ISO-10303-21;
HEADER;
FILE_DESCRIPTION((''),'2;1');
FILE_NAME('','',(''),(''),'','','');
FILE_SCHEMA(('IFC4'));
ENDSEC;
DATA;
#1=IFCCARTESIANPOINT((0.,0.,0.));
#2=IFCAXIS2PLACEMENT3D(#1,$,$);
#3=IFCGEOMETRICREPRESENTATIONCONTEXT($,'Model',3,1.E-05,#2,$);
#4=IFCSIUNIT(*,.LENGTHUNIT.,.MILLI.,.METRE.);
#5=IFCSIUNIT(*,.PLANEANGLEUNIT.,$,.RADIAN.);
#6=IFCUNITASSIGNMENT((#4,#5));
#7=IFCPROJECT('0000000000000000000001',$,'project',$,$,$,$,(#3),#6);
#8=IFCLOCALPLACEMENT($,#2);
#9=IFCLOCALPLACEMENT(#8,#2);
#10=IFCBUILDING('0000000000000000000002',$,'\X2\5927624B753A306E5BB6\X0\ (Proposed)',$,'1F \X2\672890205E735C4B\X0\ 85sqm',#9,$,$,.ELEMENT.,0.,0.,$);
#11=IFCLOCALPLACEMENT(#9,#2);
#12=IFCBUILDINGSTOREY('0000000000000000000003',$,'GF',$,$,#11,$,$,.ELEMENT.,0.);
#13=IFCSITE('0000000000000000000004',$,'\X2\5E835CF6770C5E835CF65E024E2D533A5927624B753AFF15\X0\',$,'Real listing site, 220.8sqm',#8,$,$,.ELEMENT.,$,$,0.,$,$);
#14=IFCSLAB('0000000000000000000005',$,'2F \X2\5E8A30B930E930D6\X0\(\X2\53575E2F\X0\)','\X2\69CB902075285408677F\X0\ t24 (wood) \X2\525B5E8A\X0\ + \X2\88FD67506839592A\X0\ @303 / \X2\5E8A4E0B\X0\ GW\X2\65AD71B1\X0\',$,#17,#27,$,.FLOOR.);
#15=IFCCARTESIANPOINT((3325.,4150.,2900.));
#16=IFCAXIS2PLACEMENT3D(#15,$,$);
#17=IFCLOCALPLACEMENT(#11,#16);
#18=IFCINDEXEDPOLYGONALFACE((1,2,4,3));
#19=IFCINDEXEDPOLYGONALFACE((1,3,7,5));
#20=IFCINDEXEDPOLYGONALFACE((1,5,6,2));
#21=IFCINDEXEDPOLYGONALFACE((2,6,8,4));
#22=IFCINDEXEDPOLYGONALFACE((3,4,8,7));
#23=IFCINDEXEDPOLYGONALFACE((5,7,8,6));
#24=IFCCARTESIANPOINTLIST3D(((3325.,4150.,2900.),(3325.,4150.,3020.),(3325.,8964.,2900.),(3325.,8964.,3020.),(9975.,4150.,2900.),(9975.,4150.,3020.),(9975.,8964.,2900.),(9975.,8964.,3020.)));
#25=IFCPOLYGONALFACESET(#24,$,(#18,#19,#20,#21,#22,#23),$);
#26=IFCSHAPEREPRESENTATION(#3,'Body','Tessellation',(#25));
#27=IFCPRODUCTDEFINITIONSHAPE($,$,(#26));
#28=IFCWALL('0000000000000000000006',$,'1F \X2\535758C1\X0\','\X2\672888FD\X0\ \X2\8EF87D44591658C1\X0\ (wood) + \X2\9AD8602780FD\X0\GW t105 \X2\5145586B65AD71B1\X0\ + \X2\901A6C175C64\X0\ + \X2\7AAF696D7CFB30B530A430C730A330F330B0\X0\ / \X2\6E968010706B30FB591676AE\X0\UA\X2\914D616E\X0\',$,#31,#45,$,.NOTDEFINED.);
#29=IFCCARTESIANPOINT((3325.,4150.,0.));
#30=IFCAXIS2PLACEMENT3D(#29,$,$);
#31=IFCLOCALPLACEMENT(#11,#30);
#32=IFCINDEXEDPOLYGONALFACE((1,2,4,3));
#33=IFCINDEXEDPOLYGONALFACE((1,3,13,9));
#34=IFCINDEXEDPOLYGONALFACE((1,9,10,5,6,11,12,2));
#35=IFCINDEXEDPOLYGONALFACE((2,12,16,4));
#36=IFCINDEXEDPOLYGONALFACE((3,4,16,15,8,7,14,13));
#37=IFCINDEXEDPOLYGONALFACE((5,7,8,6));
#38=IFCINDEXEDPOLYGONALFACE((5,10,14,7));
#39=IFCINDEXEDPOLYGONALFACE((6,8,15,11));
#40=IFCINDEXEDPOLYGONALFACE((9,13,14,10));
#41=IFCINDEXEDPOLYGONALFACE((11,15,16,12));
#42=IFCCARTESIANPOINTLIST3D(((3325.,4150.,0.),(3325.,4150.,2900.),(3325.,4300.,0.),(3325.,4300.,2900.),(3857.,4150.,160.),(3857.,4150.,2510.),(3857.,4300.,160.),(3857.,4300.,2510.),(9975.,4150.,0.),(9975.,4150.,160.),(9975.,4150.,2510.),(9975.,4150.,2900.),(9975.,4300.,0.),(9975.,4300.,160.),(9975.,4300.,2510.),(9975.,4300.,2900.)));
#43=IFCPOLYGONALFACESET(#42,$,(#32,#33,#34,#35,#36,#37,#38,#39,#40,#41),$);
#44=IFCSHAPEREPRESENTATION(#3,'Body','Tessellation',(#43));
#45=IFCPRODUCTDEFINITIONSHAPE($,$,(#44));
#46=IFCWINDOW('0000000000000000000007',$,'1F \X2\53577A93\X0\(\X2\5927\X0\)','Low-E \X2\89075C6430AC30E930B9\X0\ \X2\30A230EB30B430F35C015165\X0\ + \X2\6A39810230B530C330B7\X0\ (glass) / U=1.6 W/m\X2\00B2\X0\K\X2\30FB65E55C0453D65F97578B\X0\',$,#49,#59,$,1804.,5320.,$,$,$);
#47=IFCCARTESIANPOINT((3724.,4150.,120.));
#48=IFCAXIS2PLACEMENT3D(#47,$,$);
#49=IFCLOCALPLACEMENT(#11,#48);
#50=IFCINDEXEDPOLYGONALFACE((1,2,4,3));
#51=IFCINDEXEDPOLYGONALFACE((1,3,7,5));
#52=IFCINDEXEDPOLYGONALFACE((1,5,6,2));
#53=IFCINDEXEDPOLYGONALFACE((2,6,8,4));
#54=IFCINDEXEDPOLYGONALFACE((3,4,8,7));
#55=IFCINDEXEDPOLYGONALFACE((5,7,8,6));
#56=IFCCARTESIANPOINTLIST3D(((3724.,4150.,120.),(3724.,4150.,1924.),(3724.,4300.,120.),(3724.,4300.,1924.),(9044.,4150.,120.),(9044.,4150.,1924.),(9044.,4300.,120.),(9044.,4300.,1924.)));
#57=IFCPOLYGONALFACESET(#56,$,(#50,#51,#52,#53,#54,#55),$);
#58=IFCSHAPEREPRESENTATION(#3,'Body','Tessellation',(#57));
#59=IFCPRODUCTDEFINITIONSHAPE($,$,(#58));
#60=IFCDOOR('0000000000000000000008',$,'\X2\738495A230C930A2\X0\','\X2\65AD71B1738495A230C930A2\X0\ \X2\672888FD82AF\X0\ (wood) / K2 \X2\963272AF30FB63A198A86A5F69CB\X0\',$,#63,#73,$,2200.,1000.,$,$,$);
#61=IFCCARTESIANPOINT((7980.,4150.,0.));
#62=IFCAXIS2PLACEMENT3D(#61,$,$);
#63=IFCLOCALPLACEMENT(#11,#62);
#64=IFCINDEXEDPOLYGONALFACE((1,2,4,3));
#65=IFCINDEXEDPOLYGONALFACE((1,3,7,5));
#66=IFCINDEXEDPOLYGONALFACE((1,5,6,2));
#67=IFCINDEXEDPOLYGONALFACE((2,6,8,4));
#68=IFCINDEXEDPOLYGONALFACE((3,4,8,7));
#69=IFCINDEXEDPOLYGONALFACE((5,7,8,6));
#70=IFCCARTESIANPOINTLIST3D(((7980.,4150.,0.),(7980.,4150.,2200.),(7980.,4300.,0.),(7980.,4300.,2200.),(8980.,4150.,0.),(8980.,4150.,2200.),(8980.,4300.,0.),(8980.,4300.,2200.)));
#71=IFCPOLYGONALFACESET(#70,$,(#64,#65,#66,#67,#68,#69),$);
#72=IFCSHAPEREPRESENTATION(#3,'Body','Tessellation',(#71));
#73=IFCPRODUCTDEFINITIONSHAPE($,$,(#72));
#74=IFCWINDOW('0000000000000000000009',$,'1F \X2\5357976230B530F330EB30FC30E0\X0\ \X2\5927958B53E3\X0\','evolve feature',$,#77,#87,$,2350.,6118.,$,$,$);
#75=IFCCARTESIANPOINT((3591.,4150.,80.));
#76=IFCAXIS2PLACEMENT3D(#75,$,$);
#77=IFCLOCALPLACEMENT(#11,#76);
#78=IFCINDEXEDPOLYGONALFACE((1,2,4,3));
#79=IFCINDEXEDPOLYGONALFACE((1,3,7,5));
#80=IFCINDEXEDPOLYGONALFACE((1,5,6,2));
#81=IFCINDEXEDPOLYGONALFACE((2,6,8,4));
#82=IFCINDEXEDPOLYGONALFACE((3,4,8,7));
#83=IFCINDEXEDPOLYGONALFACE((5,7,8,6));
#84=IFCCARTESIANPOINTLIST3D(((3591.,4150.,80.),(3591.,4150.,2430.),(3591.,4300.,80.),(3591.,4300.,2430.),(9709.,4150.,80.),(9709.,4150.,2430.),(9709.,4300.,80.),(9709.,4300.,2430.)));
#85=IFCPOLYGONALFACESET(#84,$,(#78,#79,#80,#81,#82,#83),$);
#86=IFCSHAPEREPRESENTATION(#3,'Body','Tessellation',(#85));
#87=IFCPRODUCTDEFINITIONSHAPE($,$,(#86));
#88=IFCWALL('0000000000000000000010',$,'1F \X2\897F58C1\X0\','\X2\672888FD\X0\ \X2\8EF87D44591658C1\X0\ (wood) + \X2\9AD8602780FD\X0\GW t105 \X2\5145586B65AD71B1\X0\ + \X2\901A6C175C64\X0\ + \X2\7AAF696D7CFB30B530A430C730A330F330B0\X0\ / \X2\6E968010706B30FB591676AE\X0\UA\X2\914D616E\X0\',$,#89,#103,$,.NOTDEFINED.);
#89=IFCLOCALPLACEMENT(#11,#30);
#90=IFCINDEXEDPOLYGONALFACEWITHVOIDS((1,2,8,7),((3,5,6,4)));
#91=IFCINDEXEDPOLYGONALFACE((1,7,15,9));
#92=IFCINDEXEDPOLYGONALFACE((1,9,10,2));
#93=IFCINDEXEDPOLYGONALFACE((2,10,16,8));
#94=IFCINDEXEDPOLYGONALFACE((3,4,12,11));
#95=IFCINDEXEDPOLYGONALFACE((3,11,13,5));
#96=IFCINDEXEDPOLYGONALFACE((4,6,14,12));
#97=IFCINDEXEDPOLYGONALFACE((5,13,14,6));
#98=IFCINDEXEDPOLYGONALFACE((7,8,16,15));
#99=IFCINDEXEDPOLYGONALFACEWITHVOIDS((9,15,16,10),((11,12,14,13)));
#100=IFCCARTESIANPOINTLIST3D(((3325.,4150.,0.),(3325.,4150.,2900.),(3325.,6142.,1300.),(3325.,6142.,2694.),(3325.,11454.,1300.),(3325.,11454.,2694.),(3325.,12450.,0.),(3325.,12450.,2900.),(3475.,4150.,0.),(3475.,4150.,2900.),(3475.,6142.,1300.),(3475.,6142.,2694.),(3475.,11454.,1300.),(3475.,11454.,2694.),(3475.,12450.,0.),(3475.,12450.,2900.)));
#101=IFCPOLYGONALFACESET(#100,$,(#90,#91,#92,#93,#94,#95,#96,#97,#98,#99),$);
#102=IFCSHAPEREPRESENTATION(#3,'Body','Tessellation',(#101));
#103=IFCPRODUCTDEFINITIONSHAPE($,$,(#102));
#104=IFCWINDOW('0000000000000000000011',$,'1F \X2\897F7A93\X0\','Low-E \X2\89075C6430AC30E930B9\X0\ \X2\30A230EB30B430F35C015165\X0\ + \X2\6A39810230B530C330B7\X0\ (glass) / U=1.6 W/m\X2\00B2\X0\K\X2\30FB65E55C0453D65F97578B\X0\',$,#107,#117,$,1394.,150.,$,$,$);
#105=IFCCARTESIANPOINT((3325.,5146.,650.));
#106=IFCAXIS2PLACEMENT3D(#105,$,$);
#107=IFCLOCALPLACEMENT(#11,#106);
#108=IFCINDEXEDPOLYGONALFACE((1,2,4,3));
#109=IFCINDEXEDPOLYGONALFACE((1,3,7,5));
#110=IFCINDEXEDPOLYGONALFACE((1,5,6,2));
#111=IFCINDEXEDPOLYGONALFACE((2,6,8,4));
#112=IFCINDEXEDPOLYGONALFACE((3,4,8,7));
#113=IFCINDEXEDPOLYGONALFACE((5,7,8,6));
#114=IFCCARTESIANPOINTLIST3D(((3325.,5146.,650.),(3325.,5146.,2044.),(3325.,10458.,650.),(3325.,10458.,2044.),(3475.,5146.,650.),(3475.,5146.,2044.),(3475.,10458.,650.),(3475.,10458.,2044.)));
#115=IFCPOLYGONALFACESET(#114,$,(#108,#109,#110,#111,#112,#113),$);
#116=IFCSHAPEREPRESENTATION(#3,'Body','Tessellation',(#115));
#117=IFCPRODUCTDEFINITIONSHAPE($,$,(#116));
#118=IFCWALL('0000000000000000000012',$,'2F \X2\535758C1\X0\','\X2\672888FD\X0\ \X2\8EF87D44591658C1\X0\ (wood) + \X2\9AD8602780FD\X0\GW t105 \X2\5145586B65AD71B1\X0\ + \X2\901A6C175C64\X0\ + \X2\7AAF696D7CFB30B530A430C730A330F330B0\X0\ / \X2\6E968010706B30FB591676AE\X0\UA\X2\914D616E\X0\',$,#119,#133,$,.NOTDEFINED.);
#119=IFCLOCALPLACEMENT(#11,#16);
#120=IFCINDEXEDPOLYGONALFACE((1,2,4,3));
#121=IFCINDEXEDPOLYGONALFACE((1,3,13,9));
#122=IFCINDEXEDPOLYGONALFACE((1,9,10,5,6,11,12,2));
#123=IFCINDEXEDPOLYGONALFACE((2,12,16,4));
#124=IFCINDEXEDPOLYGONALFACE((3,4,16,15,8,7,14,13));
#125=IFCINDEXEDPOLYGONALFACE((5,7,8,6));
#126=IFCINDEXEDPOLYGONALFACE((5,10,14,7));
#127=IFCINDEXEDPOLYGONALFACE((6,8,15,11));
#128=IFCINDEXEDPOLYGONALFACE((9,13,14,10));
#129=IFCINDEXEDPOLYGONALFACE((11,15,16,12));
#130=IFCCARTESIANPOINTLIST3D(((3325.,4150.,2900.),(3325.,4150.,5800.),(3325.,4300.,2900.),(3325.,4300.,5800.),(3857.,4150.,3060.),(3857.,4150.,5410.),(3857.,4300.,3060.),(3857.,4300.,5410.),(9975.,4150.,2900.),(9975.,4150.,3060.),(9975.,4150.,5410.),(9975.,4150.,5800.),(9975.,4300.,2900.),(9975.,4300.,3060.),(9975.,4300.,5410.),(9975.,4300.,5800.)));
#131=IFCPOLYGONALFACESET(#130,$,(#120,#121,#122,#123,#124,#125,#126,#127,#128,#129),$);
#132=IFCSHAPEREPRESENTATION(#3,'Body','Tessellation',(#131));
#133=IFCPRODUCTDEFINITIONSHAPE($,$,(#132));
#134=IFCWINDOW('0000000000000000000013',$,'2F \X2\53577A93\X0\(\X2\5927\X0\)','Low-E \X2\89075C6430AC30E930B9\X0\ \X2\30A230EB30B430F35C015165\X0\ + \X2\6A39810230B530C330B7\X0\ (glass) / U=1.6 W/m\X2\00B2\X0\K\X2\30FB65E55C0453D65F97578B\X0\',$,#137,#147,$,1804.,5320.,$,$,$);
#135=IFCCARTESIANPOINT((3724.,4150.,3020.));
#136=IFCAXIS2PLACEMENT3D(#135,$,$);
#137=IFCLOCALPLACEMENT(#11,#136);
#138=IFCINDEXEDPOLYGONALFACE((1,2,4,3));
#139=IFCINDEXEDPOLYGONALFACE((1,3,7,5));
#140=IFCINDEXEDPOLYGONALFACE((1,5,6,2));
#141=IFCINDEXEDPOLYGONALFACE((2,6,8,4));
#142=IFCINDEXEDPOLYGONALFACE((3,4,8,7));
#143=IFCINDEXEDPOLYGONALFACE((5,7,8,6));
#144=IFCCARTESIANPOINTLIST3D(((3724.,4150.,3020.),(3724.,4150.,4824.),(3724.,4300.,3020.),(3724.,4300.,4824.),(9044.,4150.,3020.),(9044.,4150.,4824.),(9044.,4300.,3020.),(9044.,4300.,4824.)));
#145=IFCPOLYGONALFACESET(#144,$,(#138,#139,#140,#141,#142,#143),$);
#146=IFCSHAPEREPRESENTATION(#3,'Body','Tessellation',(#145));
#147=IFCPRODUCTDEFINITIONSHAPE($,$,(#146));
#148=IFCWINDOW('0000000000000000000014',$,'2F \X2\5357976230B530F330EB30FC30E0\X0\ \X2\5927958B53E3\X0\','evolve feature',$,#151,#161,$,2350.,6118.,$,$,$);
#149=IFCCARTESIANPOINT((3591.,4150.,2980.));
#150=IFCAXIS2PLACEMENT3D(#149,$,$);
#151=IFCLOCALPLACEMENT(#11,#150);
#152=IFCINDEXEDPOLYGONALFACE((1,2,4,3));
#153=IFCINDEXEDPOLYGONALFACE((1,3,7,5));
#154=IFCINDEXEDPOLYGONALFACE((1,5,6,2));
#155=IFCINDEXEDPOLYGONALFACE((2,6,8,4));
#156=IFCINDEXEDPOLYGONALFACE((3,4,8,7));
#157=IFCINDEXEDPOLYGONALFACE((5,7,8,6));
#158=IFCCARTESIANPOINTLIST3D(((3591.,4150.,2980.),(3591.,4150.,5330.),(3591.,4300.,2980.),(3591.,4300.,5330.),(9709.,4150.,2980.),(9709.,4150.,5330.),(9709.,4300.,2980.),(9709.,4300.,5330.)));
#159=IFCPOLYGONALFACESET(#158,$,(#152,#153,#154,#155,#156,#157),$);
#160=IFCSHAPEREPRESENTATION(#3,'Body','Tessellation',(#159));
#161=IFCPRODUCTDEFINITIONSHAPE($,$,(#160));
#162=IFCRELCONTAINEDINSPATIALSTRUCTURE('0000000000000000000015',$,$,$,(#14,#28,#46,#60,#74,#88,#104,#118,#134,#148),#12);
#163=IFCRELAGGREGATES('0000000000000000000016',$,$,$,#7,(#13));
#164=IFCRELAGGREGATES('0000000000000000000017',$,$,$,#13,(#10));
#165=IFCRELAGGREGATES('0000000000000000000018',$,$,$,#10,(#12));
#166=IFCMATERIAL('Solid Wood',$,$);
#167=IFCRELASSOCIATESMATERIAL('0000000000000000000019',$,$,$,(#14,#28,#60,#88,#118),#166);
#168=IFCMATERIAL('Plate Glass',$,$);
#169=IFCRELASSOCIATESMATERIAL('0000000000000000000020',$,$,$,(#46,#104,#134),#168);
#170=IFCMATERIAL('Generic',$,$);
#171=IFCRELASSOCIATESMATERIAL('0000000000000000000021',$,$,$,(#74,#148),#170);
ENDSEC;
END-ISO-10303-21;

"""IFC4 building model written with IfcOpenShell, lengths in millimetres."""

from ifc_helpers import new_model, si_unit, frame, frame_2d, origin, place, context, project, spatial, rectangle, extrude, material, element, fill, save


model = new_model("IFC4")

# Units and contexts
model_context = context("Model", 3, precision=1e-05, world=origin())
ifc_project = project(units=[si_unit("LENGTHUNIT", "METRE", prefix="MILLI"), si_unit("PLANEANGLEUNIT", "RADIAN")], contexts=[model_context])

# Site, building, storey
site_placement = place(None, origin())
site = spatial("IfcSite", under=ifc_project, at=site_placement, Name="広島県広島市中区大手町５", ObjectType="Real listing site, 220.8sqm", CompositionType="ELEMENT", RefElevation=0.0)
building_placement = place(site_placement, origin())
building = spatial("IfcBuilding", under=site, at=building_placement, Name="大手町の家 (Proposed)", ObjectType="1F 木造平屋 85sqm", CompositionType="ELEMENT", ElevationOfRefHeight=0.0, ElevationOfTerrain=0.0)
storey_placement = place(building_placement, origin())
storey = spatial("IfcBuildingStorey", under=building, at=storey_placement, Name="GF", CompositionType="ELEMENT", Elevation=0.0)

# Slab
ifc_material_1 = material(Name="Solid Wood")
slab_1_placement = place(storey_placement, frame((3325.0, 4150.0, 2900.0)))
element("IfcSlab", 1, at=slab_1_placement, inside=storey, material=ifc_material_1, Name="2F 床スラブ(南帯)", Description="構造用合板 t24 (wood) 剛床 + 製材根太 @303 / 床下 GW断熱", PredefinedType="FLOOR", context=model_context, shape_type="SweptSolid", body=[
    extrude(rectangle(XDim=6650.0, YDim=4814.0, at=frame_2d((3325.0, 2407.0))), frame((3325.0, 4150.0, 2900.0)), (0.0, 0.0, 1.0), 120.0),
])
ifc_material_2 = material(Name="Generic")

# Wall, openings, windows, door
wall_1_placement = place(storey_placement, frame((3325.0, 4150.0, 0.0)))
wall_1 = element("IfcWall", 2, at=wall_1_placement, inside=storey, material=ifc_material_1, Name="1F 南壁", Description="木製 軸組外壁 (wood) + 高性能GW t105 充填断熱 + 通気層 + 窯業系サイディング / 準耐火・外皮UA配慮", PredefinedType="NOTDEFINED", context=model_context, shape_type="SweptSolid", body=[
    extrude(rectangle(XDim=6650.0, YDim=150.0, at=frame_2d((3325.0, 75.0))), frame((3325.0, 4150.0, 0.0)), (0.0, 0.0, 1.0), 2900.0),
])
opening_1_placement = place(storey_placement, frame((3724.0, 4150.0, 120.0)))
opening_1 = element("IfcOpeningElement", 3, at=opening_1_placement, cuts=wall_1, PredefinedType="NOTDEFINED", context=model_context, shape_type="SweptSolid", body=[
    extrude(rectangle(XDim=5320.0, YDim=150.0, at=frame_2d((2660.0, 75.0))), frame((3724.0, 4150.0, 120.0)), (0.0, 0.0, 1.0), 1804.0),
])
opening_2_placement = place(storey_placement, frame((7980.0, 4150.0, 0.0)))
opening_2 = element("IfcOpeningElement", 4, at=opening_2_placement, cuts=wall_1, PredefinedType="NOTDEFINED", context=model_context, shape_type="SweptSolid", body=[
    extrude(rectangle(XDim=1000.0, YDim=150.0, at=frame_2d((500.0, 75.0))), frame((7980.0, 4150.0, 0.0)), (0.0, 0.0, 1.0), 2200.0),
])
opening_3_placement = place(storey_placement, frame((3591.0, 4150.0, 80.0)))
opening_3 = element("IfcOpeningElement", 5, at=opening_3_placement, cuts=wall_1, PredefinedType="NOTDEFINED", context=model_context, shape_type="SweptSolid", body=[
    extrude(rectangle(XDim=6118.0, YDim=150.0, at=frame_2d((3059.0, 75.0))), frame((3591.0, 4150.0, 80.0)), (0.0, 0.0, 1.0), 2350.0),
])
ifc_material_3 = material(Name="Plate Glass")
window_1_placement = place(storey_placement, frame((3724.0, 4150.0, 120.0)))
window_1 = element("IfcWindow", 6, at=window_1_placement, inside=storey, material=ifc_material_3, Name="1F 南窓(大)", Description="Low-E 複層ガラス アルゴン封入 + 樹脂サッシ (glass) / U=1.6 W/m²K・日射取得型", OverallHeight=1804.0, OverallWidth=5320.0, context=model_context, shape_type="SweptSolid", body=[
    extrude(rectangle(XDim=5320.0, YDim=150.0, at=frame_2d((2660.0, 75.0))), frame((3724.0, 4150.0, 120.0)), (0.0, 0.0, 1.0), 1804.0),
])
fill(opening_1, window_1)
door_placement = place(storey_placement, frame((7980.0, 4150.0, 0.0)))
door = element("IfcDoor", 7, at=door_placement, inside=storey, material=ifc_material_1, Name="玄関ドア", Description="断熱玄関ドア 木製芯 (wood) / K2 防犯・採風機構", OverallHeight=2200.0, OverallWidth=1000.0, context=model_context, shape_type="SweptSolid", body=[
    extrude(rectangle(XDim=1000.0, YDim=150.0, at=frame_2d((500.0, 75.0))), frame((7980.0, 4150.0, 0.0)), (0.0, 0.0, 1.0), 2200.0),
])
fill(opening_2, door)
window_2_placement = place(storey_placement, frame((3591.0, 4150.0, 80.0)))
window_2 = element("IfcWindow", 8, at=window_2_placement, inside=storey, material=ifc_material_2, Name="1F 南面サンルーム 大開口", Description="evolve feature", OverallHeight=2350.0, OverallWidth=6118.0, context=model_context, shape_type="SweptSolid", body=[
    extrude(rectangle(XDim=6118.0, YDim=150.0, at=frame_2d((3059.0, 75.0))), frame((3591.0, 4150.0, 80.0)), (0.0, 0.0, 1.0), 2350.0),
])
fill(opening_3, window_2)

# Wall, opening, window
wall_2_placement = place(storey_placement, frame((3325.0, 4150.0, 0.0)))
wall_2 = element("IfcWall", 9, at=wall_2_placement, inside=storey, material=ifc_material_1, Name="1F 西壁", Description="木製 軸組外壁 (wood) + 高性能GW t105 充填断熱 + 通気層 + 窯業系サイディング / 準耐火・外皮UA配慮", PredefinedType="NOTDEFINED", context=model_context, shape_type="SweptSolid", body=[
    extrude(rectangle(XDim=150.0, YDim=8300.0, at=frame_2d((75.0, 4150.0))), frame((3325.0, 4150.0, 0.0)), (0.0, 0.0, 1.0), 2900.0),
])
opening_4_placement = place(storey_placement, frame((3325.0, 5146.0, 650.0)))
opening_4 = element("IfcOpeningElement", 10, at=opening_4_placement, cuts=wall_2, PredefinedType="NOTDEFINED", context=model_context, shape_type="SweptSolid", body=[
    extrude(rectangle(XDim=150.0, YDim=5312.0, at=frame_2d((75.0, 2656.0))), frame((3325.0, 5146.0, 650.0)), (0.0, 0.0, 1.0), 1394.0),
])
window_3_placement = place(storey_placement, frame((3325.0, 5146.0, 650.0)))
window_3 = element("IfcWindow", 11, at=window_3_placement, inside=storey, material=ifc_material_3, Name="1F 西窓", Description="Low-E 複層ガラス アルゴン封入 + 樹脂サッシ (glass) / U=1.6 W/m²K・日射取得型", OverallHeight=1394.0, OverallWidth=150.0, context=model_context, shape_type="SweptSolid", body=[
    extrude(rectangle(XDim=150.0, YDim=5312.0, at=frame_2d((75.0, 2656.0))), frame((3325.0, 5146.0, 650.0)), (0.0, 0.0, 1.0), 1394.0),
])
fill(opening_4, window_3)

# Wall, openings, windows
wall_3_placement = place(storey_placement, frame((3325.0, 4150.0, 2900.0)))
wall_3 = element("IfcWall", 12, at=wall_3_placement, inside=storey, material=ifc_material_1, Name="2F 南壁", Description="木製 軸組外壁 (wood) + 高性能GW t105 充填断熱 + 通気層 + 窯業系サイディング / 準耐火・外皮UA配慮", PredefinedType="NOTDEFINED", context=model_context, shape_type="SweptSolid", body=[
    extrude(rectangle(XDim=6650.0, YDim=150.0, at=frame_2d((3325.0, 75.0))), frame((3325.0, 4150.0, 2900.0)), (0.0, 0.0, 1.0), 2900.0),
])
opening_5_placement = place(storey_placement, frame((3724.0, 4150.0, 3020.0)))
opening_5 = element("IfcOpeningElement", 13, at=opening_5_placement, cuts=wall_3, PredefinedType="NOTDEFINED", context=model_context, shape_type="SweptSolid", body=[
    extrude(rectangle(XDim=5320.0, YDim=150.0, at=frame_2d((2660.0, 75.0))), frame((3724.0, 4150.0, 3020.0)), (0.0, 0.0, 1.0), 1804.0),
])
opening_6_placement = place(storey_placement, frame((3591.0, 4150.0, 2980.0)))
opening_6 = element("IfcOpeningElement", 14, at=opening_6_placement, cuts=wall_3, PredefinedType="NOTDEFINED", context=model_context, shape_type="SweptSolid", body=[
    extrude(rectangle(XDim=6118.0, YDim=150.0, at=frame_2d((3059.0, 75.0))), frame((3591.0, 4150.0, 2980.0)), (0.0, 0.0, 1.0), 2350.0),
])
window_4_placement = place(storey_placement, frame((3724.0, 4150.0, 3020.0)))
window_4 = element("IfcWindow", 15, at=window_4_placement, inside=storey, material=ifc_material_3, Name="2F 南窓(大)", Description="Low-E 複層ガラス アルゴン封入 + 樹脂サッシ (glass) / U=1.6 W/m²K・日射取得型", OverallHeight=1804.0, OverallWidth=5320.0, context=model_context, shape_type="SweptSolid", body=[
    extrude(rectangle(XDim=5320.0, YDim=150.0, at=frame_2d((2660.0, 75.0))), frame((3724.0, 4150.0, 3020.0)), (0.0, 0.0, 1.0), 1804.0),
])
fill(opening_5, window_4)
window_5_placement = place(storey_placement, frame((3591.0, 4150.0, 2980.0)))
window_5 = element("IfcWindow", 16, at=window_5_placement, inside=storey, material=ifc_material_2, Name="2F 南面サンルーム 大開口", Description="evolve feature", OverallHeight=2350.0, OverallWidth=6118.0, context=model_context, shape_type="SweptSolid", body=[
    extrude(rectangle(XDim=6118.0, YDim=150.0, at=frame_2d((3059.0, 75.0))), frame((3591.0, 4150.0, 2980.0)), (0.0, 0.0, 1.0), 2350.0),
])
fill(opening_6, window_5)

save(model, "model.ifc")
